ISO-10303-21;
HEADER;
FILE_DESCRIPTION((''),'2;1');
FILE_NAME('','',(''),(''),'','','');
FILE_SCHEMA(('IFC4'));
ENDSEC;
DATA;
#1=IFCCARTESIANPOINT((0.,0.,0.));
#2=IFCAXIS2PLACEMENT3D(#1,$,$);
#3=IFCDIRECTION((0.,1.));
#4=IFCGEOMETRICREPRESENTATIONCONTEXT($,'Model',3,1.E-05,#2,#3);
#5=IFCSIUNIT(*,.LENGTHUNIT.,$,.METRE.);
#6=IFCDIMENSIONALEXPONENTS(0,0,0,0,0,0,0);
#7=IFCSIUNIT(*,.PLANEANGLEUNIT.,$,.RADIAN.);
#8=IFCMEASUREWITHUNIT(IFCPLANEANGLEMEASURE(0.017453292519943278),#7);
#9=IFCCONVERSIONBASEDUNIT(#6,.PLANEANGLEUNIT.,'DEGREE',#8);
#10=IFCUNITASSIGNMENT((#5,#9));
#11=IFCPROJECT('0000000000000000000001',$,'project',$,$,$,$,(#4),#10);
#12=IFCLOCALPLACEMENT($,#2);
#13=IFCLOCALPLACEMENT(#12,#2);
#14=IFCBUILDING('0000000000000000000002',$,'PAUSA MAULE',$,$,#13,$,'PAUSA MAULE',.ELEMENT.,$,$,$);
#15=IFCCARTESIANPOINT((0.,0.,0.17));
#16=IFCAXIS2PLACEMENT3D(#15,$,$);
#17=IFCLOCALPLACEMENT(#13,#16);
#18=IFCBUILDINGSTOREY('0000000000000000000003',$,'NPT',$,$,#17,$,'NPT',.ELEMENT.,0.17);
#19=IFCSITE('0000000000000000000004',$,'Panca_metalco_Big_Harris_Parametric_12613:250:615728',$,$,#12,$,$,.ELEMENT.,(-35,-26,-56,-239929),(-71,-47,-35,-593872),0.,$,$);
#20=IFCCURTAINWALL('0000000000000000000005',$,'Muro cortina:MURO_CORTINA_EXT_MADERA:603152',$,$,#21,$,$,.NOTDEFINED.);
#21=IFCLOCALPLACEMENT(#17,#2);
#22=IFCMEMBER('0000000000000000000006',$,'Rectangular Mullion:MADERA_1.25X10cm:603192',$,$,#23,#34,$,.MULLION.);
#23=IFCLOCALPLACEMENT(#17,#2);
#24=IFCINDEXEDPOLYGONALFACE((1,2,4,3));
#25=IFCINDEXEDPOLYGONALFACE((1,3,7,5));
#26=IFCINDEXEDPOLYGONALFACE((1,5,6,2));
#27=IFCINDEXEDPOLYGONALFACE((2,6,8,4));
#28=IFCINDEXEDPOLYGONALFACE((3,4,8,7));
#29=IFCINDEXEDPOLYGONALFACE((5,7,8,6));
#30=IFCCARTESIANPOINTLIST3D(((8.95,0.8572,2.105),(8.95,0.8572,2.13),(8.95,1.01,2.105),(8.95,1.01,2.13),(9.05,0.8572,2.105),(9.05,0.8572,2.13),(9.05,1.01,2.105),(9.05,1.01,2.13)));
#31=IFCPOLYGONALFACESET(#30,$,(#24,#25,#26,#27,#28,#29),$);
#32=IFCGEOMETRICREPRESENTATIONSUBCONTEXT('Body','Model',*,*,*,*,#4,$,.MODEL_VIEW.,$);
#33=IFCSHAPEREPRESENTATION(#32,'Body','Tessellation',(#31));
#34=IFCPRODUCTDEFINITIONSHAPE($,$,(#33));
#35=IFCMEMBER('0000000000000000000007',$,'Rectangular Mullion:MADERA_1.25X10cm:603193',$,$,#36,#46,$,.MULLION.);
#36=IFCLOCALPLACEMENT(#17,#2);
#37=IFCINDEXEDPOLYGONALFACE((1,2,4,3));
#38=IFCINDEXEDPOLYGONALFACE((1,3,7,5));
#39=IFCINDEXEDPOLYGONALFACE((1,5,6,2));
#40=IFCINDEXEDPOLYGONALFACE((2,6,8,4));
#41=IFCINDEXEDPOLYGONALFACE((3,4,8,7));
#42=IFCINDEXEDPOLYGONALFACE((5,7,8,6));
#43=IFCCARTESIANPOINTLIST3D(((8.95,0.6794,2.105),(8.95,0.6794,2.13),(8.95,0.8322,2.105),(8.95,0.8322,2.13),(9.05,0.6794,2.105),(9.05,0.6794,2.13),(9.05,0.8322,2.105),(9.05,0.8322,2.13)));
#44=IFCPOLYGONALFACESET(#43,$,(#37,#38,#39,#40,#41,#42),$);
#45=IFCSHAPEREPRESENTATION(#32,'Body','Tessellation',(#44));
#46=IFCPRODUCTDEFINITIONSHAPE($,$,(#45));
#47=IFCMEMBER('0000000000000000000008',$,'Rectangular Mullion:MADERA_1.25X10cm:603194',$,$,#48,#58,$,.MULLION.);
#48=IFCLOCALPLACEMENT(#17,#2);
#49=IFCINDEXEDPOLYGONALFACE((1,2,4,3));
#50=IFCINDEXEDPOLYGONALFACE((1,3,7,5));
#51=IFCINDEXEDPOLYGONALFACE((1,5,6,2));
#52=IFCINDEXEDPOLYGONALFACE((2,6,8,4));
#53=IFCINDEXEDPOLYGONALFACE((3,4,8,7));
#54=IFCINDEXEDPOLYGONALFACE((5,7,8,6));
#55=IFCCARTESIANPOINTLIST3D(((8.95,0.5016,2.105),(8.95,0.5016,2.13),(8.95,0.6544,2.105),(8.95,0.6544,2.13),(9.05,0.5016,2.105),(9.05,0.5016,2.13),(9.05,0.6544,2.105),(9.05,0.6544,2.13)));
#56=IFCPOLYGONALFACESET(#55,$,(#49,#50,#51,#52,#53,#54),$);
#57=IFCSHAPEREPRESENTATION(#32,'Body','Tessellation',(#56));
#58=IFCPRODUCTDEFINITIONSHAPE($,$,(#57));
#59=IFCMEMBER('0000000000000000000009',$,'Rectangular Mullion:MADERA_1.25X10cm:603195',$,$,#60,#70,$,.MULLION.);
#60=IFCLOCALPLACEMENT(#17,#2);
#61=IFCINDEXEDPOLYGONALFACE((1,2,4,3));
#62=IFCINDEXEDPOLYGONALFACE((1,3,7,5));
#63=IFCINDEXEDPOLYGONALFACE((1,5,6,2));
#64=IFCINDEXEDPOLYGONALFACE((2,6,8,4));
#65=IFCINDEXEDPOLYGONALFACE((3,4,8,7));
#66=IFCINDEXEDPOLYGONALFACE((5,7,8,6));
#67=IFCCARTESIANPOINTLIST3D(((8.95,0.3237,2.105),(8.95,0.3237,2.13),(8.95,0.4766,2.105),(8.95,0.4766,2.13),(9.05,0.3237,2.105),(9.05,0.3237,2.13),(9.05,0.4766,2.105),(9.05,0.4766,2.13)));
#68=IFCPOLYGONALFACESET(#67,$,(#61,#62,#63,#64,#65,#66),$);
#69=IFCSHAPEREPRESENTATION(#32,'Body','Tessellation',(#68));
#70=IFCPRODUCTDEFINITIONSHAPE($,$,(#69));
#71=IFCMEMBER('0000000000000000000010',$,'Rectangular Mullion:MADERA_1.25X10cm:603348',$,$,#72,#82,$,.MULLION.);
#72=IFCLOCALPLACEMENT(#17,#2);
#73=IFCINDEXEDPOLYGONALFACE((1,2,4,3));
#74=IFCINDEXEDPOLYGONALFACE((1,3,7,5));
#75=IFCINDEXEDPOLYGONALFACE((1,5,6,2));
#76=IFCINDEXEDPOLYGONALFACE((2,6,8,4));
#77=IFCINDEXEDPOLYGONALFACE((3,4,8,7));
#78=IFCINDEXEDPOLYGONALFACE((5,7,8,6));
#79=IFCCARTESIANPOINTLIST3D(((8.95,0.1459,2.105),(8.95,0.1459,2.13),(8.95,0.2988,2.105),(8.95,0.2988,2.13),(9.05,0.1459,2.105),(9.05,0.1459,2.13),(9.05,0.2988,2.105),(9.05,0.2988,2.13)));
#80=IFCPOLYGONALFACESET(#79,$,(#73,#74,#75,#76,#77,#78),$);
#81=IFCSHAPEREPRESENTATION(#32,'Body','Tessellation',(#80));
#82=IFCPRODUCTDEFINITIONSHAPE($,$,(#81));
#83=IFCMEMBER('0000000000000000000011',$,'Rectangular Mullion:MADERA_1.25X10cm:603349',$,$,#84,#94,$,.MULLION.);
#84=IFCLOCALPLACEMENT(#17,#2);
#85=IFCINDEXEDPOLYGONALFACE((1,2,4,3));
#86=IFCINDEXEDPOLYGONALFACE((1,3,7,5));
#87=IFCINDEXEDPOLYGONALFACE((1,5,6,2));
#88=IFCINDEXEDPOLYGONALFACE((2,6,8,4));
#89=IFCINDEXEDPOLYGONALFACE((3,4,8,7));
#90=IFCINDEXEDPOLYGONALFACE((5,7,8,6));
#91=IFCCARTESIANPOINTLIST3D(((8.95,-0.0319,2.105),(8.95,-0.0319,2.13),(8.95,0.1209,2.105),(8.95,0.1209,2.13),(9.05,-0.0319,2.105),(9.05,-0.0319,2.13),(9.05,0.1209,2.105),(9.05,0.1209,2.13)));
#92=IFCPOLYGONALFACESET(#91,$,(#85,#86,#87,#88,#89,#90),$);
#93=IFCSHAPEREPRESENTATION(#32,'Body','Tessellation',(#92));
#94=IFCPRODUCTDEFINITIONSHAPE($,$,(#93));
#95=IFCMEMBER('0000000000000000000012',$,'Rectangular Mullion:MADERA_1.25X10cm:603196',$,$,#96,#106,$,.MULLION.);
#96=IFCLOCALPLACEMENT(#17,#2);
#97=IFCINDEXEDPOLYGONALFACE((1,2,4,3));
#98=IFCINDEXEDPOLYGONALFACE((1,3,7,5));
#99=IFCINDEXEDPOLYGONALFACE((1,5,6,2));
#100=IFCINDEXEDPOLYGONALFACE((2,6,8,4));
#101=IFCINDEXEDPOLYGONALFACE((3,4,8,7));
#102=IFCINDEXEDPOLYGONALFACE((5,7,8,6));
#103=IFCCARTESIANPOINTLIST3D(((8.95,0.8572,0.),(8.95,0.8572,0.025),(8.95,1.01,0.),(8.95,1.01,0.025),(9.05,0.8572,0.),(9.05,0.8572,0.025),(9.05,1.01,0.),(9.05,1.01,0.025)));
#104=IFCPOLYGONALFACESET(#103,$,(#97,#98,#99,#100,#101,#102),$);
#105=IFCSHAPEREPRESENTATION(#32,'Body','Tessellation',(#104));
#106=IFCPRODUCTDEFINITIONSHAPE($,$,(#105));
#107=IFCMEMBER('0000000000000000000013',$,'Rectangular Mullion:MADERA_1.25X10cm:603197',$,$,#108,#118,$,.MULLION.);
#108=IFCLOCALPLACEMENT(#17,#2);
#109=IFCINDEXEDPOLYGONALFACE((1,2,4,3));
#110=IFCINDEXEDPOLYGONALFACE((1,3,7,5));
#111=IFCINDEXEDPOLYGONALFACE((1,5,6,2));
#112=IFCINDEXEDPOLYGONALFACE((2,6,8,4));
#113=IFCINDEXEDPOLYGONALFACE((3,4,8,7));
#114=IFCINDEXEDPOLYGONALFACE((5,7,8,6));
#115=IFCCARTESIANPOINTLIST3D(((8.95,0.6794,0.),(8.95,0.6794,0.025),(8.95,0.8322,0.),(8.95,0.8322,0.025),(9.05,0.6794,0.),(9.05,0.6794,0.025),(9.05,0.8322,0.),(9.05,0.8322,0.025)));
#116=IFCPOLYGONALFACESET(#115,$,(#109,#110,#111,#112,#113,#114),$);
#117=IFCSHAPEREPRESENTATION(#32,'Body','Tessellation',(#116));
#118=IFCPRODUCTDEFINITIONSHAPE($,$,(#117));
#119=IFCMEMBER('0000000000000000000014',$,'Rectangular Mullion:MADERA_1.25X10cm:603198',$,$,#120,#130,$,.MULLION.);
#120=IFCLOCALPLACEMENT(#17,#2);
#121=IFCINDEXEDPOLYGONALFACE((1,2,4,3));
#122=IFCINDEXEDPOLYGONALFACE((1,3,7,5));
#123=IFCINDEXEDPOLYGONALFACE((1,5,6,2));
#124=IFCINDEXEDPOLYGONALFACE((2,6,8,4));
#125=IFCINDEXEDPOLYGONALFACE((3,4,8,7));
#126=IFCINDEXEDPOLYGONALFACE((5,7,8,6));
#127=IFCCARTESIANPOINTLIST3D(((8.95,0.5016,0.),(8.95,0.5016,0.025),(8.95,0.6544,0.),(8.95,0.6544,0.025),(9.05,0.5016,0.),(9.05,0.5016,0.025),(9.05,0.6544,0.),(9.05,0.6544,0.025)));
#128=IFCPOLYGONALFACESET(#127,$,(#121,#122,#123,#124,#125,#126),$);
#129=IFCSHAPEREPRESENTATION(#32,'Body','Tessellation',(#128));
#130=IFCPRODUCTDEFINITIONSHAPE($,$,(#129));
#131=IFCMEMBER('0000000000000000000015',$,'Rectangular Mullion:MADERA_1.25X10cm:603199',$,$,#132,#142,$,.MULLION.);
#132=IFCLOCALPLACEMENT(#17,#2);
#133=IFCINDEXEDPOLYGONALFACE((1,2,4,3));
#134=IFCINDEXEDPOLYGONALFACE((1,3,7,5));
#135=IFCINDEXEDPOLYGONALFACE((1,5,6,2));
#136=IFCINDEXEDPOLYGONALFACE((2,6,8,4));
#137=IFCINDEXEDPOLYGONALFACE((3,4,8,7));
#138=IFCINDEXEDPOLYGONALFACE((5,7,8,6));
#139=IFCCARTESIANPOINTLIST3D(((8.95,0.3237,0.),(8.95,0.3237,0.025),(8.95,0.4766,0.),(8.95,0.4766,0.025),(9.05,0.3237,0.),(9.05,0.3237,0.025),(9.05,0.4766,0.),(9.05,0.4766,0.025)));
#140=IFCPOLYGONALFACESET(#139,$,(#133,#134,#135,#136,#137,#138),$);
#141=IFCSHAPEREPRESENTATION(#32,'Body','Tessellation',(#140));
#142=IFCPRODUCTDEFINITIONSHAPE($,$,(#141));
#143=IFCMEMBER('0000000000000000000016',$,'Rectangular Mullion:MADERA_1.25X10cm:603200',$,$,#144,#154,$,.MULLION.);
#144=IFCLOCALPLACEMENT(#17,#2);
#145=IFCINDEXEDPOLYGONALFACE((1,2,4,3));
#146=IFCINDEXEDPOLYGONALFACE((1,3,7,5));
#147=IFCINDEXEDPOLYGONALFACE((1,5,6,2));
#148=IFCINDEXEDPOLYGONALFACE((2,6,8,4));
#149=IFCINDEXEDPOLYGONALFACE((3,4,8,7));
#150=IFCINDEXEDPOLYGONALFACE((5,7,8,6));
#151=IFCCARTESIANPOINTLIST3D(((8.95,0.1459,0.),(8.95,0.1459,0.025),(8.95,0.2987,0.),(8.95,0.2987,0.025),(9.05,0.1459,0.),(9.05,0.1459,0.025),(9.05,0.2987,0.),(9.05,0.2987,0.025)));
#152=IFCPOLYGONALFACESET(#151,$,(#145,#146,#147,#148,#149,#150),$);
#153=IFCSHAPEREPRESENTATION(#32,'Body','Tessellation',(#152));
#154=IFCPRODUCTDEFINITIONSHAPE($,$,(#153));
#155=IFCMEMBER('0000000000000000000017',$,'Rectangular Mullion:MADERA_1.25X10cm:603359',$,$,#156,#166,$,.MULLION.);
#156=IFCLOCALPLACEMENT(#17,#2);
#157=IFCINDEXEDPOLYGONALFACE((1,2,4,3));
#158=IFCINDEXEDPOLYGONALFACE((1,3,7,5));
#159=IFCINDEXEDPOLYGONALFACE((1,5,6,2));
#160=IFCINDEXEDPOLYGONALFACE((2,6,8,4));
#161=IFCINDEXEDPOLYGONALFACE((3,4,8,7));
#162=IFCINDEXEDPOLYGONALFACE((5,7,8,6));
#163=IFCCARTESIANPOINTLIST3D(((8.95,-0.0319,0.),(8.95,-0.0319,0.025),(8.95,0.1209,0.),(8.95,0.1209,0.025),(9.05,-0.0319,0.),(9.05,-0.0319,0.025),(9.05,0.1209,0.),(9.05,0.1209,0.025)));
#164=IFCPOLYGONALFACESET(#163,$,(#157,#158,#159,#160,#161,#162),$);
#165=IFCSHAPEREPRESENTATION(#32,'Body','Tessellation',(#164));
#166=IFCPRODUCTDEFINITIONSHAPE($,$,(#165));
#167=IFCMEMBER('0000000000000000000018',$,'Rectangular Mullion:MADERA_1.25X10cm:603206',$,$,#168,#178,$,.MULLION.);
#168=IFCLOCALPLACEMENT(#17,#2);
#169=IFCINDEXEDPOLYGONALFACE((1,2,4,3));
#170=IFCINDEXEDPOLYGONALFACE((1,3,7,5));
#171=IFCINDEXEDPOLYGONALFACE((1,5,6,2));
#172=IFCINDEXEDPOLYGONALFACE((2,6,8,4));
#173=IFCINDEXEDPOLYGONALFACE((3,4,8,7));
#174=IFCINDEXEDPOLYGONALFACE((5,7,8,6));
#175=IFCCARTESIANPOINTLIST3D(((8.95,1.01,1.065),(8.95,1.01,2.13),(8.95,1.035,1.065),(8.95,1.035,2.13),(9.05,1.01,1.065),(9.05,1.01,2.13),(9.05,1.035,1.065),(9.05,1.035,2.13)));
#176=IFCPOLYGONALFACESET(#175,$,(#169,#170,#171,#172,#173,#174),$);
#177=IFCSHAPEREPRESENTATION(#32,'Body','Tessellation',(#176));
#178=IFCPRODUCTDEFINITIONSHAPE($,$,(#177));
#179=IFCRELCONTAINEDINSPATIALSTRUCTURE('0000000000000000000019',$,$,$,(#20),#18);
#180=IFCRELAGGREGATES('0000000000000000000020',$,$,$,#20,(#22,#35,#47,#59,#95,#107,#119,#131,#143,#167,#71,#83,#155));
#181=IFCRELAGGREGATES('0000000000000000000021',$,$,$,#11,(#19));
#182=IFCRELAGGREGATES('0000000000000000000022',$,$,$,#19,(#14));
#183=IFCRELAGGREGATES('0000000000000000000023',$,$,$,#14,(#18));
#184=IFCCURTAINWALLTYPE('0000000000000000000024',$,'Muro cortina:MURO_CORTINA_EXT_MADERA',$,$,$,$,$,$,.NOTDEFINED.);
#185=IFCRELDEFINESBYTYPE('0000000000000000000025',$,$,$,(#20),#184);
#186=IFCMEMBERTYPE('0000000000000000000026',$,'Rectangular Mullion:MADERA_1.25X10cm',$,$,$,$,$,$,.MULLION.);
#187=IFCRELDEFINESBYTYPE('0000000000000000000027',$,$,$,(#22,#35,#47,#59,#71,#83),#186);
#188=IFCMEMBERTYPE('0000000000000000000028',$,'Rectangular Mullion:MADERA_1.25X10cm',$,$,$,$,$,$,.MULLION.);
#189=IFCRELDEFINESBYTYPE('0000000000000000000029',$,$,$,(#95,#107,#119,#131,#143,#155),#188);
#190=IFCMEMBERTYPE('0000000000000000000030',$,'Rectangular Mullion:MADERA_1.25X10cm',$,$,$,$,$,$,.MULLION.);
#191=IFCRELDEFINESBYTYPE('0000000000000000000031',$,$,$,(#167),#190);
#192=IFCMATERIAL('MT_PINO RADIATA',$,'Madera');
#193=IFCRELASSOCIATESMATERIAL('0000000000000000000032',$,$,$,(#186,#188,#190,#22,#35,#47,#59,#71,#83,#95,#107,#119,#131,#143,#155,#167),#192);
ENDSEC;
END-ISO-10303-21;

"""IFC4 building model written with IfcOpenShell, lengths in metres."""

from ifc_helpers import new_model, entity, si_unit, converted_unit, direction, frame, frame_2d, origin, place, context, subcontext, project, spatial, rectangle, extrude, source, transform, mapped, material, material_profile, profile_set, profile_usage, type_object, type_shapes, element, aggregate, save


model = new_model("IFC4")

# Units and contexts
model_context = context("Model", 3, precision=1e-05, world=origin(), true_north=direction((0.0, 1.0)))
body_context = subcontext(model_context, "Body", "Model", "MODEL_VIEW")
ifc_project = project(units=[si_unit("LENGTHUNIT", "METRE"), converted_unit("PLANEANGLEUNIT", "DEGREE", entity("IfcPlaneAngleMeasure", 0.017453292519943278), si_unit("PLANEANGLEUNIT", "RADIAN"), dimensions=[0, 0, 0, 0, 0, 0, 0])], contexts=[model_context])

# Site, building, storey
site_placement = place(None, origin())
site = spatial("IfcSite", under=ifc_project, at=site_placement, Name="Panca_metalco_Big_Harris_Parametric_12613:250:615728", CompositionType="ELEMENT", RefLatitude=(-35, -26, -56, -239929), RefLongitude=(-71, -47, -35, -593872), RefElevation=0.0)
building_placement = place(site_placement, origin())
building = spatial("IfcBuilding", under=site, at=building_placement, Name="PAUSA MAULE", LongName="PAUSA MAULE", CompositionType="ELEMENT")
storey_placement = place(building_placement, frame((0.0, 0.0, 0.17)))
storey = spatial("IfcBuildingStorey", under=building, at=storey_placement, Name="NPT", LongName="NPT", CompositionType="ELEMENT", Elevation=0.17)

# Curtain wall, members
curtain_wall_type = type_object("IfcCurtainWallType", Name="Muro cortina:MURO_CORTINA_EXT_MADERA", PredefinedType="NOTDEFINED")
curtain_wall_placement = place(storey_placement, frame((0.0, 0.0, -0.17)))
curtain_wall = element("IfcCurtainWall", 1, at=curtain_wall_placement, inside=storey, type_object=curtain_wall_type, Name="Muro cortina:MURO_CORTINA_EXT_MADERA:603152", PredefinedType="NOTDEFINED")
ifc_material = material(Name="MT_PINO RADIATA", Category="Madera")
ifc_material_profile = material_profile(ifc_material, rectangle(XDim=0.025, YDim=0.1, at=frame_2d((0.0, 0.0), x_axis=(1.0, 0.0))), Name="MADERA_1.25X10cm")
ifc_profile_set = profile_set([ifc_material_profile], Name="MADERA_1.25X10cm")
ifc_profile_usage = profile_usage(ifc_profile_set)
member_type_1 = type_object("IfcMemberType", Name="Rectangular Mullion:MADERA_1.25X10cm", PredefinedType="MULLION", material=ifc_profile_set)
shared_shape_1 = source(origin(), body_context, "Body", "SweptSolid", [
    extrude(rectangle(XDim=0.025, YDim=0.1, at=frame_2d((0.0, 0.0), x_axis=(1.0, 0.0))), frame((-0.0125, 0.0, -0.1528), z_axis=(0.0, 0.0, 1.0), x_axis=(-1.0, 0.0, 0.0)), (0.0, 0.0, 1.0), 0.1528),
])
type_shapes(member_type_1, [shared_shape_1])
member_1_placement = place(curtain_wall_placement, frame((9.0, 0.8572, 2.3), z_axis=(0.0, -1.0, 0.0), x_axis=(0.0, 0.0, 1.0)))
member_1 = element("IfcMember", 2, at=member_1_placement, type_object=member_type_1, material=ifc_profile_usage, Name="Rectangular Mullion:MADERA_1.25X10cm:603192", PredefinedType="MULLION", context=body_context, shape_type="MappedRepresentation", body=[
    mapped(shared_shape_1, transform((0.0, 0.0, 0.0), scale=1.0)),
])
member_2_placement = place(curtain_wall_placement, frame((9.0, 0.6794, 2.3), z_axis=(0.0, -1.0, 0.0), x_axis=(0.0, 0.0, 1.0)))
member_2 = element("IfcMember", 3, at=member_2_placement, type_object=member_type_1, material=ifc_profile_usage, Name="Rectangular Mullion:MADERA_1.25X10cm:603193", PredefinedType="MULLION", context=body_context, shape_type="MappedRepresentation", body=[
    mapped(shared_shape_1, transform((0.0, 0.0, 0.0), scale=1.0)),
])
member_3_placement = place(curtain_wall_placement, frame((9.0, 0.5016, 2.3), z_axis=(0.0, -1.0, 0.0), x_axis=(0.0, 0.0, 1.0)))
member_3 = element("IfcMember", 4, at=member_3_placement, type_object=member_type_1, material=ifc_profile_usage, Name="Rectangular Mullion:MADERA_1.25X10cm:603194", PredefinedType="MULLION", context=body_context, shape_type="MappedRepresentation", body=[
    mapped(shared_shape_1, transform((0.0, 0.0, 0.0), scale=1.0)),
])
member_4_placement = place(curtain_wall_placement, frame((9.0, 0.3237, 2.3), z_axis=(0.0, -1.0, 0.0), x_axis=(0.0, 0.0, 1.0)))
member_4 = element("IfcMember", 5, at=member_4_placement, type_object=member_type_1, material=ifc_profile_usage, Name="Rectangular Mullion:MADERA_1.25X10cm:603195", PredefinedType="MULLION", context=body_context, shape_type="MappedRepresentation", body=[
    mapped(shared_shape_1, transform((0.0, 0.0, 0.0), scale=1.0)),
])
member_5_placement = place(curtain_wall_placement, frame((9.0, 0.1459, 2.3), z_axis=(0.0, -1.0, 0.0), x_axis=(0.0, 0.0, 1.0)))
member_5 = element("IfcMember", 6, at=member_5_placement, type_object=member_type_1, material=ifc_profile_usage, Name="Rectangular Mullion:MADERA_1.25X10cm:603348", PredefinedType="MULLION", context=body_context, shape_type="MappedRepresentation", body=[
    mapped(shared_shape_1, transform((0.0, 0.0, 0.0), scale=1.0)),
])
member_6_placement = place(curtain_wall_placement, frame((9.0, -0.0319, 2.3), z_axis=(0.0, -1.0, 0.0), x_axis=(0.0, 0.0, 1.0)))
member_6 = element("IfcMember", 7, at=member_6_placement, type_object=member_type_1, material=ifc_profile_usage, Name="Rectangular Mullion:MADERA_1.25X10cm:603349", PredefinedType="MULLION", context=body_context, shape_type="MappedRepresentation", body=[
    mapped(shared_shape_1, transform((0.0, 0.0, 0.0), scale=1.0)),
])
member_type_2 = type_object("IfcMemberType", Name="Rectangular Mullion:MADERA_1.25X10cm", PredefinedType="MULLION", material=ifc_profile_set)
shared_shape_2 = source(origin(), body_context, "Body", "SweptSolid", [
    extrude(rectangle(XDim=0.025, YDim=0.1, at=frame_2d((0.0, 0.0), x_axis=(1.0, 0.0))), frame((-0.0125, 0.0, -0.1528), z_axis=(0.0, 0.0, 1.0), x_axis=(-1.0, 0.0, 0.0)), (0.0, 0.0, 1.0), 0.1528),
])
type_shapes(member_type_2, [shared_shape_2])
member_7_placement = place(curtain_wall_placement, frame((9.0, 1.01, 0.17), z_axis=(0.0, 1.0, 0.0), x_axis=(0.0, 0.0, -1.0)))
member_7 = element("IfcMember", 8, at=member_7_placement, type_object=member_type_2, material=ifc_profile_usage, Name="Rectangular Mullion:MADERA_1.25X10cm:603196", PredefinedType="MULLION", context=body_context, shape_type="MappedRepresentation", body=[
    mapped(shared_shape_2, transform((0.0, 0.0, 0.0), scale=1.0)),
])
member_8_placement = place(curtain_wall_placement, frame((9.0, 0.8322, 0.17), z_axis=(0.0, 1.0, 0.0), x_axis=(0.0, 0.0, -1.0)))
member_8 = element("IfcMember", 9, at=member_8_placement, type_object=member_type_2, material=ifc_profile_usage, Name="Rectangular Mullion:MADERA_1.25X10cm:603197", PredefinedType="MULLION", context=body_context, shape_type="MappedRepresentation", body=[
    mapped(shared_shape_2, transform((0.0, 0.0, 0.0), scale=1.0)),
])
member_9_placement = place(curtain_wall_placement, frame((9.0, 0.6544, 0.17), z_axis=(0.0, 1.0, 0.0), x_axis=(0.0, 0.0, -1.0)))
member_9 = element("IfcMember", 10, at=member_9_placement, type_object=member_type_2, material=ifc_profile_usage, Name="Rectangular Mullion:MADERA_1.25X10cm:603198", PredefinedType="MULLION", context=body_context, shape_type="MappedRepresentation", body=[
    mapped(shared_shape_2, transform((0.0, 0.0, 0.0), scale=1.0)),
])
member_10_placement = place(curtain_wall_placement, frame((9.0, 0.4766, 0.17), z_axis=(0.0, 1.0, 0.0), x_axis=(0.0, 0.0, -1.0)))
member_10 = element("IfcMember", 11, at=member_10_placement, type_object=member_type_2, material=ifc_profile_usage, Name="Rectangular Mullion:MADERA_1.25X10cm:603199", PredefinedType="MULLION", context=body_context, shape_type="MappedRepresentation", body=[
    mapped(shared_shape_2, transform((0.0, 0.0, 0.0), scale=1.0)),
])
member_11_placement = place(curtain_wall_placement, frame((9.0, 0.2987, 0.17), z_axis=(0.0, 1.0, 0.0), x_axis=(0.0, 0.0, -1.0)))
member_11 = element("IfcMember", 12, at=member_11_placement, type_object=member_type_2, material=ifc_profile_usage, Name="Rectangular Mullion:MADERA_1.25X10cm:603200", PredefinedType="MULLION", context=body_context, shape_type="MappedRepresentation", body=[
    mapped(shared_shape_2, transform((0.0, 0.0, 0.0), scale=1.0)),
])
member_12_placement = place(curtain_wall_placement, frame((9.0, 0.1209, 0.17), z_axis=(0.0, 1.0, 0.0), x_axis=(0.0, 0.0, -1.0)))
member_12 = element("IfcMember", 13, at=member_12_placement, type_object=member_type_2, material=ifc_profile_usage, Name="Rectangular Mullion:MADERA_1.25X10cm:603359", PredefinedType="MULLION", context=body_context, shape_type="MappedRepresentation", body=[
    mapped(shared_shape_2, transform((0.0, 0.0, 0.0), scale=1.0)),
])
member_type_3 = type_object("IfcMemberType", Name="Rectangular Mullion:MADERA_1.25X10cm", PredefinedType="MULLION", material=ifc_profile_set)
shared_shape_3 = source(origin(), body_context, "Body", "SweptSolid", [
    extrude(rectangle(XDim=0.025, YDim=0.1, at=frame_2d((0.0, 0.0), x_axis=(1.0, 0.0))), frame((-0.0125, 0.0, -1.065), z_axis=(0.0, 0.0, 1.0), x_axis=(-1.0, 0.0, 0.0)), (0.0, 0.0, 1.0), 1.065),
])
type_shapes(member_type_3, [shared_shape_3])
member_13_placement = place(curtain_wall_placement, frame((9.0, 1.035, 2.3), z_axis=(0.0, 0.0, 1.0), x_axis=(0.0, 1.0, 0.0)))
member_13 = element("IfcMember", 14, at=member_13_placement, type_object=member_type_3, material=ifc_profile_usage, Name="Rectangular Mullion:MADERA_1.25X10cm:603206", PredefinedType="MULLION", context=body_context, shape_type="MappedRepresentation", body=[
    mapped(shared_shape_3, transform((0.0, 0.0, 0.0), scale=1.0)),
])
aggregate(curtain_wall, [member_1, member_2, member_3, member_4, member_7, member_8, member_9, member_10, member_11, member_13, member_5, member_6, member_12])

save(model, "model.ifc")
